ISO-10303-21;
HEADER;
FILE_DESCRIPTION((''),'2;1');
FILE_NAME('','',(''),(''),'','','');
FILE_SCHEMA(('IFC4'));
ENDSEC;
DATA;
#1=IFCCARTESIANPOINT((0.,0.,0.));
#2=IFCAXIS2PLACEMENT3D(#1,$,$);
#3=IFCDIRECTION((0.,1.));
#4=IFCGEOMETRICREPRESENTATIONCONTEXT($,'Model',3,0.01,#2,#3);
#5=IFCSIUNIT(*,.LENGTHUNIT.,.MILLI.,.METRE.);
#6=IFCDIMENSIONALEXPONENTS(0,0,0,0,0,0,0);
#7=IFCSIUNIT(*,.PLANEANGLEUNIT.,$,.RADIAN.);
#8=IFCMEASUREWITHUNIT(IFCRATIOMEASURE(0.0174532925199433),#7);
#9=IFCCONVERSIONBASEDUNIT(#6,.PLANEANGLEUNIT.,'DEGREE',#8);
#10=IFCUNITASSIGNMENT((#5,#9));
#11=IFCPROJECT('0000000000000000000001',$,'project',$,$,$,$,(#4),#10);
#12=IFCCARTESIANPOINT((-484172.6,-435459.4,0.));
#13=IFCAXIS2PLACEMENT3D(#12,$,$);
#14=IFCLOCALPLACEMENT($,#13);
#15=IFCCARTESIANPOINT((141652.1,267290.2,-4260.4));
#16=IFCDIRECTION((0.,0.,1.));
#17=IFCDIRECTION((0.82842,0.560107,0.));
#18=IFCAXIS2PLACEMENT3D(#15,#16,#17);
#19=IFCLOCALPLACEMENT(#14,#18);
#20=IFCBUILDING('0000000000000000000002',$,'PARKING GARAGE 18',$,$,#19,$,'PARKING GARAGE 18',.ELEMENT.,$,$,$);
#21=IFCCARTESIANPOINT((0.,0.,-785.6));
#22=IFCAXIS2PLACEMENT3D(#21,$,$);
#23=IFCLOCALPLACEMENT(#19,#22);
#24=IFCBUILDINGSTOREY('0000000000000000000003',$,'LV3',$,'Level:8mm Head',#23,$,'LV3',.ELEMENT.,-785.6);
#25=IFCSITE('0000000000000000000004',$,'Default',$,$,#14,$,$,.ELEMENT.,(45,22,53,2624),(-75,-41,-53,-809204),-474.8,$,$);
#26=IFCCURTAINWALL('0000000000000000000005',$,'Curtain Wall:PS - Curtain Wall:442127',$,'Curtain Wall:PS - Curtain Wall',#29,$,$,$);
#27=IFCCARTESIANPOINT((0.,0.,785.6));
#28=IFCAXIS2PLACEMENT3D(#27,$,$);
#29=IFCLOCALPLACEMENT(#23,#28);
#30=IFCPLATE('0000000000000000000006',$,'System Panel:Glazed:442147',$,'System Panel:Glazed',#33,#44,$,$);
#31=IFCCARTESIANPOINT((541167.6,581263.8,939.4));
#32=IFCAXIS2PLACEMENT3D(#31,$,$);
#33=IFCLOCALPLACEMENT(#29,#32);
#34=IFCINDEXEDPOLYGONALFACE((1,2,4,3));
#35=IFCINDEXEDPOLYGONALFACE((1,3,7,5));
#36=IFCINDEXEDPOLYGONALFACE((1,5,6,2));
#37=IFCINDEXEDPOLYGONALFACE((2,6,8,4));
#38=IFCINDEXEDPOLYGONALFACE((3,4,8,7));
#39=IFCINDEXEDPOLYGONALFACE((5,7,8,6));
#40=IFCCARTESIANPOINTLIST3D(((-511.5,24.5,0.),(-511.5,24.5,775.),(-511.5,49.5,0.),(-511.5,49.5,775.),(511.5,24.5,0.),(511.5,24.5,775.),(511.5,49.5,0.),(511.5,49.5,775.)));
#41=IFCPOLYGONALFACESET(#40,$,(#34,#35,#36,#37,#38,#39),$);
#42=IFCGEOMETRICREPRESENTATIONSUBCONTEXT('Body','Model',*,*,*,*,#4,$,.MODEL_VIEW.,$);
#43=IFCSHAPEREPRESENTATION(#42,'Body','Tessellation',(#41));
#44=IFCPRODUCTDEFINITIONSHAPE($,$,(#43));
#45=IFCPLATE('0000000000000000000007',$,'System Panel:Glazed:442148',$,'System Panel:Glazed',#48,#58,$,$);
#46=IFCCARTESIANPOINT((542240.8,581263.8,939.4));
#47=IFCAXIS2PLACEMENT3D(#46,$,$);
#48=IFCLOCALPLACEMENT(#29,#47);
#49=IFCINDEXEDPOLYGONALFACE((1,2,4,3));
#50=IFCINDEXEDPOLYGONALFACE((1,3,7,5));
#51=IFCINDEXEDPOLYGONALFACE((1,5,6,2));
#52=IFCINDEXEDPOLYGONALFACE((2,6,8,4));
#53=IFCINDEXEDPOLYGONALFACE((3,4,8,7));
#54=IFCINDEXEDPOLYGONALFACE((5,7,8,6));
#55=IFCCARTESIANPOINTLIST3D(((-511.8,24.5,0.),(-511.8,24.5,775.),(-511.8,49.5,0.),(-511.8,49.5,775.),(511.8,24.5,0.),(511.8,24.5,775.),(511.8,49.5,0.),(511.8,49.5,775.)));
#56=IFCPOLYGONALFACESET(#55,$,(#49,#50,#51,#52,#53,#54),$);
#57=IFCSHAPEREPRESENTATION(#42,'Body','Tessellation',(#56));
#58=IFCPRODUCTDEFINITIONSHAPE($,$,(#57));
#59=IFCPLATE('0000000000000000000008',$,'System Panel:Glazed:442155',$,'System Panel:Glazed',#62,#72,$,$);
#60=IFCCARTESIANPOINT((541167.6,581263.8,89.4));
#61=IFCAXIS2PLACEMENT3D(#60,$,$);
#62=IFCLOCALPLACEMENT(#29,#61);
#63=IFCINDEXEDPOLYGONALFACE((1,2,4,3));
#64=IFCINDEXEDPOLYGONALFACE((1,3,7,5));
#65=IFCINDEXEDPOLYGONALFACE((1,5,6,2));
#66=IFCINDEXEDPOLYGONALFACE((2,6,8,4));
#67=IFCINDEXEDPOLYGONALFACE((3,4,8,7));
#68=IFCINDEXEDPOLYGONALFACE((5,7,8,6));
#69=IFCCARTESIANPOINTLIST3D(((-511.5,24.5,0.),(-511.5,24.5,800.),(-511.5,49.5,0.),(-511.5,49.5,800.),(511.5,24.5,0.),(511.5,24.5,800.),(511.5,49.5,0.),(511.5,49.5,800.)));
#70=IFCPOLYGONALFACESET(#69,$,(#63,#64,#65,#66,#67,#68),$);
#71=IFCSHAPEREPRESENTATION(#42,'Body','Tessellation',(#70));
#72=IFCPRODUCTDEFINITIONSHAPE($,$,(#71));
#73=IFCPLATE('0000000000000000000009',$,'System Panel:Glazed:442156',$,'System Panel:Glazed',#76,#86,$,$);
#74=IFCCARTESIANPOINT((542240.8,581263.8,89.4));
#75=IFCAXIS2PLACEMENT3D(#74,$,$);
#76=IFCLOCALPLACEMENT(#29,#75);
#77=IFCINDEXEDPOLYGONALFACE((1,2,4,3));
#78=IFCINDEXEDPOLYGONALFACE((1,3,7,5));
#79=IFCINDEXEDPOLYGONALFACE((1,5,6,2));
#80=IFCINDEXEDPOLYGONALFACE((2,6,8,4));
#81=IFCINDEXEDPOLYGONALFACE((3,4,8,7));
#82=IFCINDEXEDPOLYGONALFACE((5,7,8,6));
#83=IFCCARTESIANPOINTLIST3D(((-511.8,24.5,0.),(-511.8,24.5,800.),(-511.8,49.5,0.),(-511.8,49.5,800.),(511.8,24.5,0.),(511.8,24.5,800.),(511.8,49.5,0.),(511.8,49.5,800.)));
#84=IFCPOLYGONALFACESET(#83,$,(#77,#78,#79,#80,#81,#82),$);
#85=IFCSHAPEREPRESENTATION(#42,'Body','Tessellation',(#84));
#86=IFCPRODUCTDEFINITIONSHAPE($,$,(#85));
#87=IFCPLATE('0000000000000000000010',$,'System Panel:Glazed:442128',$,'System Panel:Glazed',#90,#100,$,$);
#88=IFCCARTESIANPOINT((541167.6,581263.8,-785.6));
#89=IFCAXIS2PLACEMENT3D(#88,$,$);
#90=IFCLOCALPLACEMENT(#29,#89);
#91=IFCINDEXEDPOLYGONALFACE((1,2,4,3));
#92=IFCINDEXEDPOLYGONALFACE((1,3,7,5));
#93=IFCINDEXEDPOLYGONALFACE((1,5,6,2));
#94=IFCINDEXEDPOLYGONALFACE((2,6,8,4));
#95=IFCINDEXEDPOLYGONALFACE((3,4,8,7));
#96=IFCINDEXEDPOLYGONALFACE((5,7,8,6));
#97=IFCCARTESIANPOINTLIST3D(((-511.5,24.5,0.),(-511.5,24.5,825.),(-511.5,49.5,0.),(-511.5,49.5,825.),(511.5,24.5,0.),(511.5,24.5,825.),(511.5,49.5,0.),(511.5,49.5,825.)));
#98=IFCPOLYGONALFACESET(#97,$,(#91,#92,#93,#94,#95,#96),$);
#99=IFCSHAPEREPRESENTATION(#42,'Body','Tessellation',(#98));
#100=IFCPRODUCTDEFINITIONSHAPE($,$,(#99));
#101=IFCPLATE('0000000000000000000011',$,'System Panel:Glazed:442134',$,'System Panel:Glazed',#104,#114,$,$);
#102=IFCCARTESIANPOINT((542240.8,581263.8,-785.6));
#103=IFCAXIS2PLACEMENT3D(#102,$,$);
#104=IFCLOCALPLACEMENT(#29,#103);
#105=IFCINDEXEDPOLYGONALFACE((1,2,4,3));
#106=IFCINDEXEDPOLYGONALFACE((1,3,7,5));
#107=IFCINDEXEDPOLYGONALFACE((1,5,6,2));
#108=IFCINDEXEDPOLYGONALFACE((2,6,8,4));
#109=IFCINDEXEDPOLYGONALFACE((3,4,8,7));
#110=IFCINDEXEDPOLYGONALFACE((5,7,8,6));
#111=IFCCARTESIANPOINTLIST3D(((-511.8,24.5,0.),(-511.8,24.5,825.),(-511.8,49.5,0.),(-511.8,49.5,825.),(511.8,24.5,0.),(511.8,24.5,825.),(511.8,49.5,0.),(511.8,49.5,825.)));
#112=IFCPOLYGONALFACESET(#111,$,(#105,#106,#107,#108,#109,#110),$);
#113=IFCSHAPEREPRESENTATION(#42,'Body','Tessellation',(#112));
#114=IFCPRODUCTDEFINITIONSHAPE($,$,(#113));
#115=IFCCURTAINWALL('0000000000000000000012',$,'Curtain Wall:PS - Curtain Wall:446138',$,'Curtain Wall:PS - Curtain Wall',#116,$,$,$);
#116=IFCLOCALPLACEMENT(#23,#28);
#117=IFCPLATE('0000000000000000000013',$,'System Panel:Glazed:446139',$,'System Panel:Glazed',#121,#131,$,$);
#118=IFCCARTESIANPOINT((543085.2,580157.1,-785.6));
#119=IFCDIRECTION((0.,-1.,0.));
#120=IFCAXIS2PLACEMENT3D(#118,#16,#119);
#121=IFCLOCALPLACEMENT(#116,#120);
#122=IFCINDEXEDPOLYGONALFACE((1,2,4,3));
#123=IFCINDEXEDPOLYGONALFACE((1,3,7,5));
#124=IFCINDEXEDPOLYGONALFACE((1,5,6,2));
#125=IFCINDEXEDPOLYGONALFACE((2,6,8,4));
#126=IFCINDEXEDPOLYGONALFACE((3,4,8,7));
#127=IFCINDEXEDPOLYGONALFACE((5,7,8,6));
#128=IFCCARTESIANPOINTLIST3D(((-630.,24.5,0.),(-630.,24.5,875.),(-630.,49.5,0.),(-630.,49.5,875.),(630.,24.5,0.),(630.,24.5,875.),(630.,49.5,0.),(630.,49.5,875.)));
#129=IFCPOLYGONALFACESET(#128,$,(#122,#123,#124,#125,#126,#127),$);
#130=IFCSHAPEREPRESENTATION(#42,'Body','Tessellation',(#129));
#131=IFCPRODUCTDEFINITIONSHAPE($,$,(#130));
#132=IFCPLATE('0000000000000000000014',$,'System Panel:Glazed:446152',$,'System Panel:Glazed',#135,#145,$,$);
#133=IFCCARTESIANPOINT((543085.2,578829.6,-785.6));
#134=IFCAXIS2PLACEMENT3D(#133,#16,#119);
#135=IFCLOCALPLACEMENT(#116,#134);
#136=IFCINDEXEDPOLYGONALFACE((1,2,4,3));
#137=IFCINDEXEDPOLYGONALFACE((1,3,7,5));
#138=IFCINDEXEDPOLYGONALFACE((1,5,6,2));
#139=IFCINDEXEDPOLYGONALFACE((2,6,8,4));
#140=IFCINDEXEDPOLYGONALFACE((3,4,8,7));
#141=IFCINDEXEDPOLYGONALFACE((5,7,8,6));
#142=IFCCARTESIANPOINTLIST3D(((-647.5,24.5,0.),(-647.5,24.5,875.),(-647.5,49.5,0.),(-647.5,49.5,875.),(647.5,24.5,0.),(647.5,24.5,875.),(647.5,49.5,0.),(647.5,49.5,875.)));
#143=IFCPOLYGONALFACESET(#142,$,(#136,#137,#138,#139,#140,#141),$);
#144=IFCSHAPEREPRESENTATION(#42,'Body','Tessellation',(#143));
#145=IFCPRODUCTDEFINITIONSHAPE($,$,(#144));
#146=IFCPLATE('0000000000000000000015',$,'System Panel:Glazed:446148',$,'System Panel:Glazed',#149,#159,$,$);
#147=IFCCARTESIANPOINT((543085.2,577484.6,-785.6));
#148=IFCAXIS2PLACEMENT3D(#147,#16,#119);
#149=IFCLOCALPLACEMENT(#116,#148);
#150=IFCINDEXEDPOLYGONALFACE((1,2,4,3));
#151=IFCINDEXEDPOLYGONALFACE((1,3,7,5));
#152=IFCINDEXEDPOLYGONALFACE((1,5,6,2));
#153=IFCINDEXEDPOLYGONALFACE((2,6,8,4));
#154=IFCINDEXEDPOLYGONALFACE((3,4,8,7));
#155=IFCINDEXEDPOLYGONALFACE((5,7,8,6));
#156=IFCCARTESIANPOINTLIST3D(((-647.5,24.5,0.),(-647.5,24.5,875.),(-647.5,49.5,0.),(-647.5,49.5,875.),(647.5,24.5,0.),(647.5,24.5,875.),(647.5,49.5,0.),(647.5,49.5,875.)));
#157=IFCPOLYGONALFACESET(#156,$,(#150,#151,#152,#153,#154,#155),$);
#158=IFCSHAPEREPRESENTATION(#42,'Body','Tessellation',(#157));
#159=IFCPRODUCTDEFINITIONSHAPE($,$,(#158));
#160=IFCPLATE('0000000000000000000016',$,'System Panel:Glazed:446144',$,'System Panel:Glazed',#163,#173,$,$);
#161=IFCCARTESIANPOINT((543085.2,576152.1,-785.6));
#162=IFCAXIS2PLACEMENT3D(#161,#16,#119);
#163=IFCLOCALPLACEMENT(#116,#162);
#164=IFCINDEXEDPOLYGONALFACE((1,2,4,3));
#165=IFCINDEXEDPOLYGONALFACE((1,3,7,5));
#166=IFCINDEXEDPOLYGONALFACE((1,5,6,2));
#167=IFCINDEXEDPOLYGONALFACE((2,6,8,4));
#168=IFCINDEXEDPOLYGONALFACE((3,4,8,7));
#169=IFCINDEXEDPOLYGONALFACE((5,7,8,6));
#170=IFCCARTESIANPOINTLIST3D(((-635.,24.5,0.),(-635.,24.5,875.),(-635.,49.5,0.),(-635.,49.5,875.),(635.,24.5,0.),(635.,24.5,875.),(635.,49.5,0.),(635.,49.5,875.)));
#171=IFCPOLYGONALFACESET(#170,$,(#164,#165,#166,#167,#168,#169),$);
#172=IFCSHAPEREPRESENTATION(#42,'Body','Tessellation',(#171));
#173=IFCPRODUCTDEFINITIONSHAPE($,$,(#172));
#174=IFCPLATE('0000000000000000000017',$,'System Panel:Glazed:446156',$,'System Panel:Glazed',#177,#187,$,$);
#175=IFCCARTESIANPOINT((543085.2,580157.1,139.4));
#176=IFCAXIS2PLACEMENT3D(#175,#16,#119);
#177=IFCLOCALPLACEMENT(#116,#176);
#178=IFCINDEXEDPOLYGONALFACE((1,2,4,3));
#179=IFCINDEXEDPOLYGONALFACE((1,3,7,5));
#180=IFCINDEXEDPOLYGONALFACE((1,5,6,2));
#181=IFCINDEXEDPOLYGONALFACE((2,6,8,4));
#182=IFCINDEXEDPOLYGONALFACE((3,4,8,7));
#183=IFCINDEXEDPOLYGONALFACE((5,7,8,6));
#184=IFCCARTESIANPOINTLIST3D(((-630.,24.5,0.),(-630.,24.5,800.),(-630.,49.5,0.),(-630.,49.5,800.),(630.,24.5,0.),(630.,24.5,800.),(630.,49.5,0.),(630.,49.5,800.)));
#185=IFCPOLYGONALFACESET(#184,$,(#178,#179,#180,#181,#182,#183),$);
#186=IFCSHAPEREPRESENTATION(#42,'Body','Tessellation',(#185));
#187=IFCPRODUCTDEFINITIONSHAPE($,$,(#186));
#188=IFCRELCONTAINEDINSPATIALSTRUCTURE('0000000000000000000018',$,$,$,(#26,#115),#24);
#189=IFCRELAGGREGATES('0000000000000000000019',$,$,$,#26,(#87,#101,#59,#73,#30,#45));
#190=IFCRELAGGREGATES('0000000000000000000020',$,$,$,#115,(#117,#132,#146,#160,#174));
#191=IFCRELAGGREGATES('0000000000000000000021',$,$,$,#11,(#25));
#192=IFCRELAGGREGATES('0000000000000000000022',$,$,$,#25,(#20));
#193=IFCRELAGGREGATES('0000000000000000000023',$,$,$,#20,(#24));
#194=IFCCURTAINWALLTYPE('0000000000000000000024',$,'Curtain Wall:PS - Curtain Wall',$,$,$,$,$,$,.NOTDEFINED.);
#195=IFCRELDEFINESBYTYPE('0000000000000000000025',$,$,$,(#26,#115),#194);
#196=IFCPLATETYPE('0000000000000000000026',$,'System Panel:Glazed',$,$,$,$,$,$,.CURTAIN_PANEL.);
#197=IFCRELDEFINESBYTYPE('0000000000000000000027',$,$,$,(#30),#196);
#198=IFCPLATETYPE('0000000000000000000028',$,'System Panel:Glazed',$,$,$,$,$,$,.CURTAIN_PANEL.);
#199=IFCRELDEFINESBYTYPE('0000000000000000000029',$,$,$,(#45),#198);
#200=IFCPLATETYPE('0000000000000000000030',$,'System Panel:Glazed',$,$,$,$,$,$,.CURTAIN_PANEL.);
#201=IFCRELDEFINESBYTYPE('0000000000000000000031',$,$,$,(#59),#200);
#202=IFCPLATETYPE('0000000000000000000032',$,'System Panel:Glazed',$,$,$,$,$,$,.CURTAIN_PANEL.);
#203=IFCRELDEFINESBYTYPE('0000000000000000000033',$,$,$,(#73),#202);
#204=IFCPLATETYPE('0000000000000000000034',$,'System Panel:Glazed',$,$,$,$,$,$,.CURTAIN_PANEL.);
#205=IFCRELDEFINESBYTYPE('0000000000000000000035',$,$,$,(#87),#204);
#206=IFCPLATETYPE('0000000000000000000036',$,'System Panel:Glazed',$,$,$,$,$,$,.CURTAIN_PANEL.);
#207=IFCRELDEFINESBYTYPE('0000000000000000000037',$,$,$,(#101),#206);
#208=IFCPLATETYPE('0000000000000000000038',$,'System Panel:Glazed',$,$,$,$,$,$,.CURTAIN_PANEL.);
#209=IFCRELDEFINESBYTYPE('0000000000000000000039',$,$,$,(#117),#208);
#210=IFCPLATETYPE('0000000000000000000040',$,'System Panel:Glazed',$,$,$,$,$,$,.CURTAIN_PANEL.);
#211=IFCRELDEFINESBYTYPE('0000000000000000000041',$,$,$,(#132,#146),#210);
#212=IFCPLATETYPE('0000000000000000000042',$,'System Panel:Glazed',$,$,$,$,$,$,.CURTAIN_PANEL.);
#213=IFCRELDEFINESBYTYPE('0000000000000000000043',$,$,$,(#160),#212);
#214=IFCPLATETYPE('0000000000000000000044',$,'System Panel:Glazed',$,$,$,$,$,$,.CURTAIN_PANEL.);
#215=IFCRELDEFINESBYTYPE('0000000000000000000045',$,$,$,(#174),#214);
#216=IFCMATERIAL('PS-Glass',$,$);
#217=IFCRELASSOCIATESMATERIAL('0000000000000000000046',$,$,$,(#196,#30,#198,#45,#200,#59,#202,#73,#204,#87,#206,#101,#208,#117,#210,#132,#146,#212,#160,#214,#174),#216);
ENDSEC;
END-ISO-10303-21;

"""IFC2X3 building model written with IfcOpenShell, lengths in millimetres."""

from ifc_helpers import new_model, entity, si_unit, converted_unit, direction, frame, origin, origin_2d_with_axis, place, context, subcontext, project, spatial, rectangle, extrude, source, transform, mapped, material, type_object, type_shapes, element, aggregate, save


model = new_model("IFC2X3")

# Units and contexts
model_context = context("Model", 3, precision=0.01, world=origin(), true_north=direction((0.0, 1.0)))
body_context = subcontext(model_context, "Body", "Model", "MODEL_VIEW")
ifc_project = project(units=[si_unit("LENGTHUNIT", "METRE", prefix="MILLI"), converted_unit("PLANEANGLEUNIT", "DEGREE", entity("IfcRatioMeasure", 0.0174532925199433), si_unit("PLANEANGLEUNIT", "RADIAN"), dimensions=[0, 0, 0, 0, 0, 0, 0])], contexts=[model_context])

# Site, building, storey
site_placement = place(None, frame((-484172.6, -435459.4, 0.0)))
site = spatial("IfcSite", under=ifc_project, at=site_placement, Name="Default", CompositionType="ELEMENT", RefLatitude=(45, 22, 53, 2624), RefLongitude=(-75, -41, -53, -809204), RefElevation=-474.8)
building_placement = place(site_placement, frame((141652.1, 267290.2, -4260.4), z_axis=(0.0, 0.0, 1.0), x_axis=(0.82842, 0.560107, 0.0)))
building = spatial("IfcBuilding", under=site, at=building_placement, Name="PARKING GARAGE 18", LongName="PARKING GARAGE 18", CompositionType="ELEMENT")
storey_placement = place(building_placement, frame((0.0, 0.0, -785.6)))
storey = spatial("IfcBuildingStorey", under=building, at=storey_placement, Name="LV3", ObjectType="Level:8mm Head", LongName="LV3", CompositionType="ELEMENT", Elevation=-785.6)

# Curtain walls, plates
curtain_wall_type = type_object("IfcCurtainWallType", Name="Curtain Wall:PS - Curtain Wall", PredefinedType="NOTDEFINED")
curtain_wall_1_placement = place(storey_placement, frame((0.0, 0.0, 785.6)))
curtain_wall_1 = element("IfcCurtainWall", 1, at=curtain_wall_1_placement, inside=storey, type_object=curtain_wall_type, Name="Curtain Wall:PS - Curtain Wall:442127", ObjectType="Curtain Wall:PS - Curtain Wall")
ifc_material_1 = material(Name="PS-Glass")
plate_type_1 = type_object("IfcPlateType", Name="System Panel:Glazed", PredefinedType="CURTAIN_PANEL", material=ifc_material_1)
shared_shape_1 = source(origin(), body_context, "Body", "SweptSolid", [
    extrude(rectangle(XDim=25.0, YDim=1023.0, at=origin_2d_with_axis()), frame((0.0, 37.0, 0.0), z_axis=(0.0, 0.0, 1.0), x_axis=(0.0, 1.0, 0.0)), (0.0, 0.0, 1.0), 775.0),
])
type_shapes(plate_type_1, [shared_shape_1])
plate_1_placement = place(curtain_wall_1_placement, frame((541167.6, 581263.8, 939.4)))
plate_1 = element("IfcPlate", 2, at=plate_1_placement, type_object=plate_type_1, material=ifc_material_1, Name="System Panel:Glazed:442147", ObjectType="System Panel:Glazed", context=body_context, shape_type="MappedRepresentation", body=[
    mapped(shared_shape_1, transform((0.0, 0.0, 0.0), scale=1.0)),
])
plate_type_2 = type_object("IfcPlateType", Name="System Panel:Glazed", PredefinedType="CURTAIN_PANEL", material=ifc_material_1)
shared_shape_2 = source(origin(), body_context, "Body", "SweptSolid", [
    extrude(rectangle(XDim=25.0, YDim=1023.5, at=origin_2d_with_axis()), frame((0.0, 37.0, 0.0), z_axis=(0.0, 0.0, 1.0), x_axis=(0.0, 1.0, 0.0)), (0.0, 0.0, 1.0), 775.0),
])
type_shapes(plate_type_2, [shared_shape_2])
plate_2_placement = place(curtain_wall_1_placement, frame((542240.8, 581263.8, 939.4)))
plate_2 = element("IfcPlate", 3, at=plate_2_placement, type_object=plate_type_2, material=ifc_material_1, Name="System Panel:Glazed:442148", ObjectType="System Panel:Glazed", context=body_context, shape_type="MappedRepresentation", body=[
    mapped(shared_shape_2, transform((0.0, 0.0, 0.0), scale=1.0)),
])
plate_type_3 = type_object("IfcPlateType", Name="System Panel:Glazed", PredefinedType="CURTAIN_PANEL", material=ifc_material_1)
shared_shape_3 = source(origin(), body_context, "Body", "SweptSolid", [
    extrude(rectangle(XDim=25.0, YDim=1023.0, at=origin_2d_with_axis()), frame((0.0, 37.0, 0.0), z_axis=(0.0, 0.0, 1.0), x_axis=(0.0, 1.0, 0.0)), (0.0, 0.0, 1.0), 800.0),
])
type_shapes(plate_type_3, [shared_shape_3])
plate_3_placement = place(curtain_wall_1_placement, frame((541167.6, 581263.8, 89.4)))
plate_3 = element("IfcPlate", 4, at=plate_3_placement, type_object=plate_type_3, material=ifc_material_1, Name="System Panel:Glazed:442155", ObjectType="System Panel:Glazed", context=body_context, shape_type="MappedRepresentation", body=[
    mapped(shared_shape_3, transform((0.0, 0.0, 0.0), scale=1.0)),
])
plate_type_4 = type_object("IfcPlateType", Name="System Panel:Glazed", PredefinedType="CURTAIN_PANEL", material=ifc_material_1)
shared_shape_4 = source(origin(), body_context, "Body", "SweptSolid", [
    extrude(rectangle(XDim=25.0, YDim=1023.5, at=origin_2d_with_axis()), frame((0.0, 37.0, 0.0), z_axis=(0.0, 0.0, 1.0), x_axis=(0.0, 1.0, 0.0)), (0.0, 0.0, 1.0), 800.0),
])
type_shapes(plate_type_4, [shared_shape_4])
plate_4_placement = place(curtain_wall_1_placement, frame((542240.8, 581263.8, 89.4)))
plate_4 = element("IfcPlate", 5, at=plate_4_placement, type_object=plate_type_4, material=ifc_material_1, Name="System Panel:Glazed:442156", ObjectType="System Panel:Glazed", context=body_context, shape_type="MappedRepresentation", body=[
    mapped(shared_shape_4, transform((0.0, 0.0, 0.0), scale=1.0)),
])
plate_type_5 = type_object("IfcPlateType", Name="System Panel:Glazed", PredefinedType="CURTAIN_PANEL", material=ifc_material_1)
shared_shape_5 = source(origin(), body_context, "Body", "SweptSolid", [
    extrude(rectangle(XDim=25.0, YDim=1023.0, at=origin_2d_with_axis()), frame((0.0, 37.0, 0.0), z_axis=(0.0, 0.0, 1.0), x_axis=(0.0, 1.0, 0.0)), (0.0, 0.0, 1.0), 825.0),
])
type_shapes(plate_type_5, [shared_shape_5])
plate_5_placement = place(curtain_wall_1_placement, frame((541167.6, 581263.8, -785.6)))
plate_5 = element("IfcPlate", 6, at=plate_5_placement, type_object=plate_type_5, material=ifc_material_1, Name="System Panel:Glazed:442128", ObjectType="System Panel:Glazed", context=body_context, shape_type="MappedRepresentation", body=[
    mapped(shared_shape_5, transform((0.0, 0.0, 0.0), scale=1.0)),
])
plate_type_6 = type_object("IfcPlateType", Name="System Panel:Glazed", PredefinedType="CURTAIN_PANEL", material=ifc_material_1)
shared_shape_6 = source(origin(), body_context, "Body", "SweptSolid", [
    extrude(rectangle(XDim=25.0, YDim=1023.5, at=origin_2d_with_axis()), frame((0.0, 37.0, 0.0), z_axis=(0.0, 0.0, 1.0), x_axis=(0.0, 1.0, 0.0)), (0.0, 0.0, 1.0), 825.0),
])
type_shapes(plate_type_6, [shared_shape_6])
plate_6_placement = place(curtain_wall_1_placement, frame((542240.8, 581263.8, -785.6)))
plate_6 = element("IfcPlate", 7, at=plate_6_placement, type_object=plate_type_6, material=ifc_material_1, Name="System Panel:Glazed:442134", ObjectType="System Panel:Glazed", context=body_context, shape_type="MappedRepresentation", body=[
    mapped(shared_shape_6, transform((0.0, 0.0, 0.0), scale=1.0)),
])
aggregate(curtain_wall_1, [plate_5, plate_6, plate_3, plate_4, plate_1, plate_2])
curtain_wall_2_placement = place(storey_placement, frame((0.0, 0.0, 785.6)))
curtain_wall_2 = element("IfcCurtainWall", 8, at=curtain_wall_2_placement, inside=storey, type_object=curtain_wall_type, Name="Curtain Wall:PS - Curtain Wall:446138", ObjectType="Curtain Wall:PS - Curtain Wall")
plate_type_7 = type_object("IfcPlateType", Name="System Panel:Glazed", PredefinedType="CURTAIN_PANEL", material=ifc_material_1)
shared_shape_7 = source(origin(), body_context, "Body", "SweptSolid", [
    extrude(rectangle(XDim=25.0, YDim=1260.1, at=origin_2d_with_axis()), frame((0.0, 37.0, 0.0), z_axis=(0.0, 0.0, 1.0), x_axis=(0.0, 1.0, 0.0)), (0.0, 0.0, 1.0), 875.0),
])
type_shapes(plate_type_7, [shared_shape_7])
plate_7_placement = place(curtain_wall_2_placement, frame((543085.2, 580157.1, -785.6), z_axis=(0.0, 0.0, 1.0), x_axis=(0.0, -1.0, 0.0)))
plate_7 = element("IfcPlate", 9, at=plate_7_placement, type_object=plate_type_7, material=ifc_material_1, Name="System Panel:Glazed:446139", ObjectType="System Panel:Glazed", context=body_context, shape_type="MappedRepresentation", body=[
    mapped(shared_shape_7, transform((0.0, 0.0, 0.0), scale=1.0)),
])
plate_type_8 = type_object("IfcPlateType", Name="System Panel:Glazed", PredefinedType="CURTAIN_PANEL", material=ifc_material_1)
shared_shape_8 = source(origin(), body_context, "Body", "SweptSolid", [
    extrude(rectangle(XDim=25.0, YDim=1295.0, at=origin_2d_with_axis()), frame((0.0, 37.0, 0.0), z_axis=(0.0, 0.0, 1.0), x_axis=(0.0, 1.0, 0.0)), (0.0, 0.0, 1.0), 875.0),
])
type_shapes(plate_type_8, [shared_shape_8])
plate_8_placement = place(curtain_wall_2_placement, frame((543085.2, 578829.6, -785.6), z_axis=(0.0, 0.0, 1.0), x_axis=(0.0, -1.0, 0.0)))
plate_8 = element("IfcPlate", 10, at=plate_8_placement, type_object=plate_type_8, material=ifc_material_1, Name="System Panel:Glazed:446152", ObjectType="System Panel:Glazed", context=body_context, shape_type="MappedRepresentation", body=[
    mapped(shared_shape_8, transform((0.0, 0.0, 0.0), scale=1.0)),
])
plate_9_placement = place(curtain_wall_2_placement, frame((543085.2, 577484.6, -785.6), z_axis=(0.0, 0.0, 1.0), x_axis=(0.0, -1.0, 0.0)))
plate_9 = element("IfcPlate", 11, at=plate_9_placement, type_object=plate_type_8, material=ifc_material_1, Name="System Panel:Glazed:446148", ObjectType="System Panel:Glazed", context=body_context, shape_type="MappedRepresentation", body=[
    mapped(shared_shape_8, transform((0.0, 0.0, 0.0), scale=1.0)),
])
plate_type_9 = type_object("IfcPlateType", Name="System Panel:Glazed", PredefinedType="CURTAIN_PANEL", material=ifc_material_1)
shared_shape_9 = source(origin(), body_context, "Body", "SweptSolid", [
    extrude(rectangle(XDim=25.0, YDim=1270.0, at=origin_2d_with_axis()), frame((0.0, 37.0, 0.0), z_axis=(0.0, 0.0, 1.0), x_axis=(0.0, 1.0, 0.0)), (0.0, 0.0, 1.0), 875.0),
])
type_shapes(plate_type_9, [shared_shape_9])
plate_10_placement = place(curtain_wall_2_placement, frame((543085.2, 576152.1, -785.6), z_axis=(0.0, 0.0, 1.0), x_axis=(0.0, -1.0, 0.0)))
plate_10 = element("IfcPlate", 12, at=plate_10_placement, type_object=plate_type_9, material=ifc_material_1, Name="System Panel:Glazed:446144", ObjectType="System Panel:Glazed", context=body_context, shape_type="MappedRepresentation", body=[
    mapped(shared_shape_9, transform((0.0, 0.0, 0.0), scale=1.0)),
])
plate_type_10 = type_object("IfcPlateType", Name="System Panel:Glazed", PredefinedType="CURTAIN_PANEL", material=ifc_material_1)
shared_shape_10 = source(origin(), body_context, "Body", "SweptSolid", [
    extrude(rectangle(XDim=25.0, YDim=1260.1, at=origin_2d_with_axis()), frame((0.0, 37.0, 0.0), z_axis=(0.0, 0.0, 1.0), x_axis=(0.0, 1.0, 0.0)), (0.0, 0.0, 1.0), 800.0),
])
type_shapes(plate_type_10, [shared_shape_10])
plate_11_placement = place(curtain_wall_2_placement, frame((543085.2, 580157.1, 139.4), z_axis=(0.0, 0.0, 1.0), x_axis=(0.0, -1.0, 0.0)))
plate_11 = element("IfcPlate", 13, at=plate_11_placement, type_object=plate_type_10, material=ifc_material_1, Name="System Panel:Glazed:446156", ObjectType="System Panel:Glazed", context=body_context, shape_type="MappedRepresentation", body=[
    mapped(shared_shape_10, transform((0.0, 0.0, 0.0), scale=1.0)),
])
aggregate(curtain_wall_2, [plate_7, plate_8, plate_9, plate_10, plate_11])

save(model, "model.ifc")
